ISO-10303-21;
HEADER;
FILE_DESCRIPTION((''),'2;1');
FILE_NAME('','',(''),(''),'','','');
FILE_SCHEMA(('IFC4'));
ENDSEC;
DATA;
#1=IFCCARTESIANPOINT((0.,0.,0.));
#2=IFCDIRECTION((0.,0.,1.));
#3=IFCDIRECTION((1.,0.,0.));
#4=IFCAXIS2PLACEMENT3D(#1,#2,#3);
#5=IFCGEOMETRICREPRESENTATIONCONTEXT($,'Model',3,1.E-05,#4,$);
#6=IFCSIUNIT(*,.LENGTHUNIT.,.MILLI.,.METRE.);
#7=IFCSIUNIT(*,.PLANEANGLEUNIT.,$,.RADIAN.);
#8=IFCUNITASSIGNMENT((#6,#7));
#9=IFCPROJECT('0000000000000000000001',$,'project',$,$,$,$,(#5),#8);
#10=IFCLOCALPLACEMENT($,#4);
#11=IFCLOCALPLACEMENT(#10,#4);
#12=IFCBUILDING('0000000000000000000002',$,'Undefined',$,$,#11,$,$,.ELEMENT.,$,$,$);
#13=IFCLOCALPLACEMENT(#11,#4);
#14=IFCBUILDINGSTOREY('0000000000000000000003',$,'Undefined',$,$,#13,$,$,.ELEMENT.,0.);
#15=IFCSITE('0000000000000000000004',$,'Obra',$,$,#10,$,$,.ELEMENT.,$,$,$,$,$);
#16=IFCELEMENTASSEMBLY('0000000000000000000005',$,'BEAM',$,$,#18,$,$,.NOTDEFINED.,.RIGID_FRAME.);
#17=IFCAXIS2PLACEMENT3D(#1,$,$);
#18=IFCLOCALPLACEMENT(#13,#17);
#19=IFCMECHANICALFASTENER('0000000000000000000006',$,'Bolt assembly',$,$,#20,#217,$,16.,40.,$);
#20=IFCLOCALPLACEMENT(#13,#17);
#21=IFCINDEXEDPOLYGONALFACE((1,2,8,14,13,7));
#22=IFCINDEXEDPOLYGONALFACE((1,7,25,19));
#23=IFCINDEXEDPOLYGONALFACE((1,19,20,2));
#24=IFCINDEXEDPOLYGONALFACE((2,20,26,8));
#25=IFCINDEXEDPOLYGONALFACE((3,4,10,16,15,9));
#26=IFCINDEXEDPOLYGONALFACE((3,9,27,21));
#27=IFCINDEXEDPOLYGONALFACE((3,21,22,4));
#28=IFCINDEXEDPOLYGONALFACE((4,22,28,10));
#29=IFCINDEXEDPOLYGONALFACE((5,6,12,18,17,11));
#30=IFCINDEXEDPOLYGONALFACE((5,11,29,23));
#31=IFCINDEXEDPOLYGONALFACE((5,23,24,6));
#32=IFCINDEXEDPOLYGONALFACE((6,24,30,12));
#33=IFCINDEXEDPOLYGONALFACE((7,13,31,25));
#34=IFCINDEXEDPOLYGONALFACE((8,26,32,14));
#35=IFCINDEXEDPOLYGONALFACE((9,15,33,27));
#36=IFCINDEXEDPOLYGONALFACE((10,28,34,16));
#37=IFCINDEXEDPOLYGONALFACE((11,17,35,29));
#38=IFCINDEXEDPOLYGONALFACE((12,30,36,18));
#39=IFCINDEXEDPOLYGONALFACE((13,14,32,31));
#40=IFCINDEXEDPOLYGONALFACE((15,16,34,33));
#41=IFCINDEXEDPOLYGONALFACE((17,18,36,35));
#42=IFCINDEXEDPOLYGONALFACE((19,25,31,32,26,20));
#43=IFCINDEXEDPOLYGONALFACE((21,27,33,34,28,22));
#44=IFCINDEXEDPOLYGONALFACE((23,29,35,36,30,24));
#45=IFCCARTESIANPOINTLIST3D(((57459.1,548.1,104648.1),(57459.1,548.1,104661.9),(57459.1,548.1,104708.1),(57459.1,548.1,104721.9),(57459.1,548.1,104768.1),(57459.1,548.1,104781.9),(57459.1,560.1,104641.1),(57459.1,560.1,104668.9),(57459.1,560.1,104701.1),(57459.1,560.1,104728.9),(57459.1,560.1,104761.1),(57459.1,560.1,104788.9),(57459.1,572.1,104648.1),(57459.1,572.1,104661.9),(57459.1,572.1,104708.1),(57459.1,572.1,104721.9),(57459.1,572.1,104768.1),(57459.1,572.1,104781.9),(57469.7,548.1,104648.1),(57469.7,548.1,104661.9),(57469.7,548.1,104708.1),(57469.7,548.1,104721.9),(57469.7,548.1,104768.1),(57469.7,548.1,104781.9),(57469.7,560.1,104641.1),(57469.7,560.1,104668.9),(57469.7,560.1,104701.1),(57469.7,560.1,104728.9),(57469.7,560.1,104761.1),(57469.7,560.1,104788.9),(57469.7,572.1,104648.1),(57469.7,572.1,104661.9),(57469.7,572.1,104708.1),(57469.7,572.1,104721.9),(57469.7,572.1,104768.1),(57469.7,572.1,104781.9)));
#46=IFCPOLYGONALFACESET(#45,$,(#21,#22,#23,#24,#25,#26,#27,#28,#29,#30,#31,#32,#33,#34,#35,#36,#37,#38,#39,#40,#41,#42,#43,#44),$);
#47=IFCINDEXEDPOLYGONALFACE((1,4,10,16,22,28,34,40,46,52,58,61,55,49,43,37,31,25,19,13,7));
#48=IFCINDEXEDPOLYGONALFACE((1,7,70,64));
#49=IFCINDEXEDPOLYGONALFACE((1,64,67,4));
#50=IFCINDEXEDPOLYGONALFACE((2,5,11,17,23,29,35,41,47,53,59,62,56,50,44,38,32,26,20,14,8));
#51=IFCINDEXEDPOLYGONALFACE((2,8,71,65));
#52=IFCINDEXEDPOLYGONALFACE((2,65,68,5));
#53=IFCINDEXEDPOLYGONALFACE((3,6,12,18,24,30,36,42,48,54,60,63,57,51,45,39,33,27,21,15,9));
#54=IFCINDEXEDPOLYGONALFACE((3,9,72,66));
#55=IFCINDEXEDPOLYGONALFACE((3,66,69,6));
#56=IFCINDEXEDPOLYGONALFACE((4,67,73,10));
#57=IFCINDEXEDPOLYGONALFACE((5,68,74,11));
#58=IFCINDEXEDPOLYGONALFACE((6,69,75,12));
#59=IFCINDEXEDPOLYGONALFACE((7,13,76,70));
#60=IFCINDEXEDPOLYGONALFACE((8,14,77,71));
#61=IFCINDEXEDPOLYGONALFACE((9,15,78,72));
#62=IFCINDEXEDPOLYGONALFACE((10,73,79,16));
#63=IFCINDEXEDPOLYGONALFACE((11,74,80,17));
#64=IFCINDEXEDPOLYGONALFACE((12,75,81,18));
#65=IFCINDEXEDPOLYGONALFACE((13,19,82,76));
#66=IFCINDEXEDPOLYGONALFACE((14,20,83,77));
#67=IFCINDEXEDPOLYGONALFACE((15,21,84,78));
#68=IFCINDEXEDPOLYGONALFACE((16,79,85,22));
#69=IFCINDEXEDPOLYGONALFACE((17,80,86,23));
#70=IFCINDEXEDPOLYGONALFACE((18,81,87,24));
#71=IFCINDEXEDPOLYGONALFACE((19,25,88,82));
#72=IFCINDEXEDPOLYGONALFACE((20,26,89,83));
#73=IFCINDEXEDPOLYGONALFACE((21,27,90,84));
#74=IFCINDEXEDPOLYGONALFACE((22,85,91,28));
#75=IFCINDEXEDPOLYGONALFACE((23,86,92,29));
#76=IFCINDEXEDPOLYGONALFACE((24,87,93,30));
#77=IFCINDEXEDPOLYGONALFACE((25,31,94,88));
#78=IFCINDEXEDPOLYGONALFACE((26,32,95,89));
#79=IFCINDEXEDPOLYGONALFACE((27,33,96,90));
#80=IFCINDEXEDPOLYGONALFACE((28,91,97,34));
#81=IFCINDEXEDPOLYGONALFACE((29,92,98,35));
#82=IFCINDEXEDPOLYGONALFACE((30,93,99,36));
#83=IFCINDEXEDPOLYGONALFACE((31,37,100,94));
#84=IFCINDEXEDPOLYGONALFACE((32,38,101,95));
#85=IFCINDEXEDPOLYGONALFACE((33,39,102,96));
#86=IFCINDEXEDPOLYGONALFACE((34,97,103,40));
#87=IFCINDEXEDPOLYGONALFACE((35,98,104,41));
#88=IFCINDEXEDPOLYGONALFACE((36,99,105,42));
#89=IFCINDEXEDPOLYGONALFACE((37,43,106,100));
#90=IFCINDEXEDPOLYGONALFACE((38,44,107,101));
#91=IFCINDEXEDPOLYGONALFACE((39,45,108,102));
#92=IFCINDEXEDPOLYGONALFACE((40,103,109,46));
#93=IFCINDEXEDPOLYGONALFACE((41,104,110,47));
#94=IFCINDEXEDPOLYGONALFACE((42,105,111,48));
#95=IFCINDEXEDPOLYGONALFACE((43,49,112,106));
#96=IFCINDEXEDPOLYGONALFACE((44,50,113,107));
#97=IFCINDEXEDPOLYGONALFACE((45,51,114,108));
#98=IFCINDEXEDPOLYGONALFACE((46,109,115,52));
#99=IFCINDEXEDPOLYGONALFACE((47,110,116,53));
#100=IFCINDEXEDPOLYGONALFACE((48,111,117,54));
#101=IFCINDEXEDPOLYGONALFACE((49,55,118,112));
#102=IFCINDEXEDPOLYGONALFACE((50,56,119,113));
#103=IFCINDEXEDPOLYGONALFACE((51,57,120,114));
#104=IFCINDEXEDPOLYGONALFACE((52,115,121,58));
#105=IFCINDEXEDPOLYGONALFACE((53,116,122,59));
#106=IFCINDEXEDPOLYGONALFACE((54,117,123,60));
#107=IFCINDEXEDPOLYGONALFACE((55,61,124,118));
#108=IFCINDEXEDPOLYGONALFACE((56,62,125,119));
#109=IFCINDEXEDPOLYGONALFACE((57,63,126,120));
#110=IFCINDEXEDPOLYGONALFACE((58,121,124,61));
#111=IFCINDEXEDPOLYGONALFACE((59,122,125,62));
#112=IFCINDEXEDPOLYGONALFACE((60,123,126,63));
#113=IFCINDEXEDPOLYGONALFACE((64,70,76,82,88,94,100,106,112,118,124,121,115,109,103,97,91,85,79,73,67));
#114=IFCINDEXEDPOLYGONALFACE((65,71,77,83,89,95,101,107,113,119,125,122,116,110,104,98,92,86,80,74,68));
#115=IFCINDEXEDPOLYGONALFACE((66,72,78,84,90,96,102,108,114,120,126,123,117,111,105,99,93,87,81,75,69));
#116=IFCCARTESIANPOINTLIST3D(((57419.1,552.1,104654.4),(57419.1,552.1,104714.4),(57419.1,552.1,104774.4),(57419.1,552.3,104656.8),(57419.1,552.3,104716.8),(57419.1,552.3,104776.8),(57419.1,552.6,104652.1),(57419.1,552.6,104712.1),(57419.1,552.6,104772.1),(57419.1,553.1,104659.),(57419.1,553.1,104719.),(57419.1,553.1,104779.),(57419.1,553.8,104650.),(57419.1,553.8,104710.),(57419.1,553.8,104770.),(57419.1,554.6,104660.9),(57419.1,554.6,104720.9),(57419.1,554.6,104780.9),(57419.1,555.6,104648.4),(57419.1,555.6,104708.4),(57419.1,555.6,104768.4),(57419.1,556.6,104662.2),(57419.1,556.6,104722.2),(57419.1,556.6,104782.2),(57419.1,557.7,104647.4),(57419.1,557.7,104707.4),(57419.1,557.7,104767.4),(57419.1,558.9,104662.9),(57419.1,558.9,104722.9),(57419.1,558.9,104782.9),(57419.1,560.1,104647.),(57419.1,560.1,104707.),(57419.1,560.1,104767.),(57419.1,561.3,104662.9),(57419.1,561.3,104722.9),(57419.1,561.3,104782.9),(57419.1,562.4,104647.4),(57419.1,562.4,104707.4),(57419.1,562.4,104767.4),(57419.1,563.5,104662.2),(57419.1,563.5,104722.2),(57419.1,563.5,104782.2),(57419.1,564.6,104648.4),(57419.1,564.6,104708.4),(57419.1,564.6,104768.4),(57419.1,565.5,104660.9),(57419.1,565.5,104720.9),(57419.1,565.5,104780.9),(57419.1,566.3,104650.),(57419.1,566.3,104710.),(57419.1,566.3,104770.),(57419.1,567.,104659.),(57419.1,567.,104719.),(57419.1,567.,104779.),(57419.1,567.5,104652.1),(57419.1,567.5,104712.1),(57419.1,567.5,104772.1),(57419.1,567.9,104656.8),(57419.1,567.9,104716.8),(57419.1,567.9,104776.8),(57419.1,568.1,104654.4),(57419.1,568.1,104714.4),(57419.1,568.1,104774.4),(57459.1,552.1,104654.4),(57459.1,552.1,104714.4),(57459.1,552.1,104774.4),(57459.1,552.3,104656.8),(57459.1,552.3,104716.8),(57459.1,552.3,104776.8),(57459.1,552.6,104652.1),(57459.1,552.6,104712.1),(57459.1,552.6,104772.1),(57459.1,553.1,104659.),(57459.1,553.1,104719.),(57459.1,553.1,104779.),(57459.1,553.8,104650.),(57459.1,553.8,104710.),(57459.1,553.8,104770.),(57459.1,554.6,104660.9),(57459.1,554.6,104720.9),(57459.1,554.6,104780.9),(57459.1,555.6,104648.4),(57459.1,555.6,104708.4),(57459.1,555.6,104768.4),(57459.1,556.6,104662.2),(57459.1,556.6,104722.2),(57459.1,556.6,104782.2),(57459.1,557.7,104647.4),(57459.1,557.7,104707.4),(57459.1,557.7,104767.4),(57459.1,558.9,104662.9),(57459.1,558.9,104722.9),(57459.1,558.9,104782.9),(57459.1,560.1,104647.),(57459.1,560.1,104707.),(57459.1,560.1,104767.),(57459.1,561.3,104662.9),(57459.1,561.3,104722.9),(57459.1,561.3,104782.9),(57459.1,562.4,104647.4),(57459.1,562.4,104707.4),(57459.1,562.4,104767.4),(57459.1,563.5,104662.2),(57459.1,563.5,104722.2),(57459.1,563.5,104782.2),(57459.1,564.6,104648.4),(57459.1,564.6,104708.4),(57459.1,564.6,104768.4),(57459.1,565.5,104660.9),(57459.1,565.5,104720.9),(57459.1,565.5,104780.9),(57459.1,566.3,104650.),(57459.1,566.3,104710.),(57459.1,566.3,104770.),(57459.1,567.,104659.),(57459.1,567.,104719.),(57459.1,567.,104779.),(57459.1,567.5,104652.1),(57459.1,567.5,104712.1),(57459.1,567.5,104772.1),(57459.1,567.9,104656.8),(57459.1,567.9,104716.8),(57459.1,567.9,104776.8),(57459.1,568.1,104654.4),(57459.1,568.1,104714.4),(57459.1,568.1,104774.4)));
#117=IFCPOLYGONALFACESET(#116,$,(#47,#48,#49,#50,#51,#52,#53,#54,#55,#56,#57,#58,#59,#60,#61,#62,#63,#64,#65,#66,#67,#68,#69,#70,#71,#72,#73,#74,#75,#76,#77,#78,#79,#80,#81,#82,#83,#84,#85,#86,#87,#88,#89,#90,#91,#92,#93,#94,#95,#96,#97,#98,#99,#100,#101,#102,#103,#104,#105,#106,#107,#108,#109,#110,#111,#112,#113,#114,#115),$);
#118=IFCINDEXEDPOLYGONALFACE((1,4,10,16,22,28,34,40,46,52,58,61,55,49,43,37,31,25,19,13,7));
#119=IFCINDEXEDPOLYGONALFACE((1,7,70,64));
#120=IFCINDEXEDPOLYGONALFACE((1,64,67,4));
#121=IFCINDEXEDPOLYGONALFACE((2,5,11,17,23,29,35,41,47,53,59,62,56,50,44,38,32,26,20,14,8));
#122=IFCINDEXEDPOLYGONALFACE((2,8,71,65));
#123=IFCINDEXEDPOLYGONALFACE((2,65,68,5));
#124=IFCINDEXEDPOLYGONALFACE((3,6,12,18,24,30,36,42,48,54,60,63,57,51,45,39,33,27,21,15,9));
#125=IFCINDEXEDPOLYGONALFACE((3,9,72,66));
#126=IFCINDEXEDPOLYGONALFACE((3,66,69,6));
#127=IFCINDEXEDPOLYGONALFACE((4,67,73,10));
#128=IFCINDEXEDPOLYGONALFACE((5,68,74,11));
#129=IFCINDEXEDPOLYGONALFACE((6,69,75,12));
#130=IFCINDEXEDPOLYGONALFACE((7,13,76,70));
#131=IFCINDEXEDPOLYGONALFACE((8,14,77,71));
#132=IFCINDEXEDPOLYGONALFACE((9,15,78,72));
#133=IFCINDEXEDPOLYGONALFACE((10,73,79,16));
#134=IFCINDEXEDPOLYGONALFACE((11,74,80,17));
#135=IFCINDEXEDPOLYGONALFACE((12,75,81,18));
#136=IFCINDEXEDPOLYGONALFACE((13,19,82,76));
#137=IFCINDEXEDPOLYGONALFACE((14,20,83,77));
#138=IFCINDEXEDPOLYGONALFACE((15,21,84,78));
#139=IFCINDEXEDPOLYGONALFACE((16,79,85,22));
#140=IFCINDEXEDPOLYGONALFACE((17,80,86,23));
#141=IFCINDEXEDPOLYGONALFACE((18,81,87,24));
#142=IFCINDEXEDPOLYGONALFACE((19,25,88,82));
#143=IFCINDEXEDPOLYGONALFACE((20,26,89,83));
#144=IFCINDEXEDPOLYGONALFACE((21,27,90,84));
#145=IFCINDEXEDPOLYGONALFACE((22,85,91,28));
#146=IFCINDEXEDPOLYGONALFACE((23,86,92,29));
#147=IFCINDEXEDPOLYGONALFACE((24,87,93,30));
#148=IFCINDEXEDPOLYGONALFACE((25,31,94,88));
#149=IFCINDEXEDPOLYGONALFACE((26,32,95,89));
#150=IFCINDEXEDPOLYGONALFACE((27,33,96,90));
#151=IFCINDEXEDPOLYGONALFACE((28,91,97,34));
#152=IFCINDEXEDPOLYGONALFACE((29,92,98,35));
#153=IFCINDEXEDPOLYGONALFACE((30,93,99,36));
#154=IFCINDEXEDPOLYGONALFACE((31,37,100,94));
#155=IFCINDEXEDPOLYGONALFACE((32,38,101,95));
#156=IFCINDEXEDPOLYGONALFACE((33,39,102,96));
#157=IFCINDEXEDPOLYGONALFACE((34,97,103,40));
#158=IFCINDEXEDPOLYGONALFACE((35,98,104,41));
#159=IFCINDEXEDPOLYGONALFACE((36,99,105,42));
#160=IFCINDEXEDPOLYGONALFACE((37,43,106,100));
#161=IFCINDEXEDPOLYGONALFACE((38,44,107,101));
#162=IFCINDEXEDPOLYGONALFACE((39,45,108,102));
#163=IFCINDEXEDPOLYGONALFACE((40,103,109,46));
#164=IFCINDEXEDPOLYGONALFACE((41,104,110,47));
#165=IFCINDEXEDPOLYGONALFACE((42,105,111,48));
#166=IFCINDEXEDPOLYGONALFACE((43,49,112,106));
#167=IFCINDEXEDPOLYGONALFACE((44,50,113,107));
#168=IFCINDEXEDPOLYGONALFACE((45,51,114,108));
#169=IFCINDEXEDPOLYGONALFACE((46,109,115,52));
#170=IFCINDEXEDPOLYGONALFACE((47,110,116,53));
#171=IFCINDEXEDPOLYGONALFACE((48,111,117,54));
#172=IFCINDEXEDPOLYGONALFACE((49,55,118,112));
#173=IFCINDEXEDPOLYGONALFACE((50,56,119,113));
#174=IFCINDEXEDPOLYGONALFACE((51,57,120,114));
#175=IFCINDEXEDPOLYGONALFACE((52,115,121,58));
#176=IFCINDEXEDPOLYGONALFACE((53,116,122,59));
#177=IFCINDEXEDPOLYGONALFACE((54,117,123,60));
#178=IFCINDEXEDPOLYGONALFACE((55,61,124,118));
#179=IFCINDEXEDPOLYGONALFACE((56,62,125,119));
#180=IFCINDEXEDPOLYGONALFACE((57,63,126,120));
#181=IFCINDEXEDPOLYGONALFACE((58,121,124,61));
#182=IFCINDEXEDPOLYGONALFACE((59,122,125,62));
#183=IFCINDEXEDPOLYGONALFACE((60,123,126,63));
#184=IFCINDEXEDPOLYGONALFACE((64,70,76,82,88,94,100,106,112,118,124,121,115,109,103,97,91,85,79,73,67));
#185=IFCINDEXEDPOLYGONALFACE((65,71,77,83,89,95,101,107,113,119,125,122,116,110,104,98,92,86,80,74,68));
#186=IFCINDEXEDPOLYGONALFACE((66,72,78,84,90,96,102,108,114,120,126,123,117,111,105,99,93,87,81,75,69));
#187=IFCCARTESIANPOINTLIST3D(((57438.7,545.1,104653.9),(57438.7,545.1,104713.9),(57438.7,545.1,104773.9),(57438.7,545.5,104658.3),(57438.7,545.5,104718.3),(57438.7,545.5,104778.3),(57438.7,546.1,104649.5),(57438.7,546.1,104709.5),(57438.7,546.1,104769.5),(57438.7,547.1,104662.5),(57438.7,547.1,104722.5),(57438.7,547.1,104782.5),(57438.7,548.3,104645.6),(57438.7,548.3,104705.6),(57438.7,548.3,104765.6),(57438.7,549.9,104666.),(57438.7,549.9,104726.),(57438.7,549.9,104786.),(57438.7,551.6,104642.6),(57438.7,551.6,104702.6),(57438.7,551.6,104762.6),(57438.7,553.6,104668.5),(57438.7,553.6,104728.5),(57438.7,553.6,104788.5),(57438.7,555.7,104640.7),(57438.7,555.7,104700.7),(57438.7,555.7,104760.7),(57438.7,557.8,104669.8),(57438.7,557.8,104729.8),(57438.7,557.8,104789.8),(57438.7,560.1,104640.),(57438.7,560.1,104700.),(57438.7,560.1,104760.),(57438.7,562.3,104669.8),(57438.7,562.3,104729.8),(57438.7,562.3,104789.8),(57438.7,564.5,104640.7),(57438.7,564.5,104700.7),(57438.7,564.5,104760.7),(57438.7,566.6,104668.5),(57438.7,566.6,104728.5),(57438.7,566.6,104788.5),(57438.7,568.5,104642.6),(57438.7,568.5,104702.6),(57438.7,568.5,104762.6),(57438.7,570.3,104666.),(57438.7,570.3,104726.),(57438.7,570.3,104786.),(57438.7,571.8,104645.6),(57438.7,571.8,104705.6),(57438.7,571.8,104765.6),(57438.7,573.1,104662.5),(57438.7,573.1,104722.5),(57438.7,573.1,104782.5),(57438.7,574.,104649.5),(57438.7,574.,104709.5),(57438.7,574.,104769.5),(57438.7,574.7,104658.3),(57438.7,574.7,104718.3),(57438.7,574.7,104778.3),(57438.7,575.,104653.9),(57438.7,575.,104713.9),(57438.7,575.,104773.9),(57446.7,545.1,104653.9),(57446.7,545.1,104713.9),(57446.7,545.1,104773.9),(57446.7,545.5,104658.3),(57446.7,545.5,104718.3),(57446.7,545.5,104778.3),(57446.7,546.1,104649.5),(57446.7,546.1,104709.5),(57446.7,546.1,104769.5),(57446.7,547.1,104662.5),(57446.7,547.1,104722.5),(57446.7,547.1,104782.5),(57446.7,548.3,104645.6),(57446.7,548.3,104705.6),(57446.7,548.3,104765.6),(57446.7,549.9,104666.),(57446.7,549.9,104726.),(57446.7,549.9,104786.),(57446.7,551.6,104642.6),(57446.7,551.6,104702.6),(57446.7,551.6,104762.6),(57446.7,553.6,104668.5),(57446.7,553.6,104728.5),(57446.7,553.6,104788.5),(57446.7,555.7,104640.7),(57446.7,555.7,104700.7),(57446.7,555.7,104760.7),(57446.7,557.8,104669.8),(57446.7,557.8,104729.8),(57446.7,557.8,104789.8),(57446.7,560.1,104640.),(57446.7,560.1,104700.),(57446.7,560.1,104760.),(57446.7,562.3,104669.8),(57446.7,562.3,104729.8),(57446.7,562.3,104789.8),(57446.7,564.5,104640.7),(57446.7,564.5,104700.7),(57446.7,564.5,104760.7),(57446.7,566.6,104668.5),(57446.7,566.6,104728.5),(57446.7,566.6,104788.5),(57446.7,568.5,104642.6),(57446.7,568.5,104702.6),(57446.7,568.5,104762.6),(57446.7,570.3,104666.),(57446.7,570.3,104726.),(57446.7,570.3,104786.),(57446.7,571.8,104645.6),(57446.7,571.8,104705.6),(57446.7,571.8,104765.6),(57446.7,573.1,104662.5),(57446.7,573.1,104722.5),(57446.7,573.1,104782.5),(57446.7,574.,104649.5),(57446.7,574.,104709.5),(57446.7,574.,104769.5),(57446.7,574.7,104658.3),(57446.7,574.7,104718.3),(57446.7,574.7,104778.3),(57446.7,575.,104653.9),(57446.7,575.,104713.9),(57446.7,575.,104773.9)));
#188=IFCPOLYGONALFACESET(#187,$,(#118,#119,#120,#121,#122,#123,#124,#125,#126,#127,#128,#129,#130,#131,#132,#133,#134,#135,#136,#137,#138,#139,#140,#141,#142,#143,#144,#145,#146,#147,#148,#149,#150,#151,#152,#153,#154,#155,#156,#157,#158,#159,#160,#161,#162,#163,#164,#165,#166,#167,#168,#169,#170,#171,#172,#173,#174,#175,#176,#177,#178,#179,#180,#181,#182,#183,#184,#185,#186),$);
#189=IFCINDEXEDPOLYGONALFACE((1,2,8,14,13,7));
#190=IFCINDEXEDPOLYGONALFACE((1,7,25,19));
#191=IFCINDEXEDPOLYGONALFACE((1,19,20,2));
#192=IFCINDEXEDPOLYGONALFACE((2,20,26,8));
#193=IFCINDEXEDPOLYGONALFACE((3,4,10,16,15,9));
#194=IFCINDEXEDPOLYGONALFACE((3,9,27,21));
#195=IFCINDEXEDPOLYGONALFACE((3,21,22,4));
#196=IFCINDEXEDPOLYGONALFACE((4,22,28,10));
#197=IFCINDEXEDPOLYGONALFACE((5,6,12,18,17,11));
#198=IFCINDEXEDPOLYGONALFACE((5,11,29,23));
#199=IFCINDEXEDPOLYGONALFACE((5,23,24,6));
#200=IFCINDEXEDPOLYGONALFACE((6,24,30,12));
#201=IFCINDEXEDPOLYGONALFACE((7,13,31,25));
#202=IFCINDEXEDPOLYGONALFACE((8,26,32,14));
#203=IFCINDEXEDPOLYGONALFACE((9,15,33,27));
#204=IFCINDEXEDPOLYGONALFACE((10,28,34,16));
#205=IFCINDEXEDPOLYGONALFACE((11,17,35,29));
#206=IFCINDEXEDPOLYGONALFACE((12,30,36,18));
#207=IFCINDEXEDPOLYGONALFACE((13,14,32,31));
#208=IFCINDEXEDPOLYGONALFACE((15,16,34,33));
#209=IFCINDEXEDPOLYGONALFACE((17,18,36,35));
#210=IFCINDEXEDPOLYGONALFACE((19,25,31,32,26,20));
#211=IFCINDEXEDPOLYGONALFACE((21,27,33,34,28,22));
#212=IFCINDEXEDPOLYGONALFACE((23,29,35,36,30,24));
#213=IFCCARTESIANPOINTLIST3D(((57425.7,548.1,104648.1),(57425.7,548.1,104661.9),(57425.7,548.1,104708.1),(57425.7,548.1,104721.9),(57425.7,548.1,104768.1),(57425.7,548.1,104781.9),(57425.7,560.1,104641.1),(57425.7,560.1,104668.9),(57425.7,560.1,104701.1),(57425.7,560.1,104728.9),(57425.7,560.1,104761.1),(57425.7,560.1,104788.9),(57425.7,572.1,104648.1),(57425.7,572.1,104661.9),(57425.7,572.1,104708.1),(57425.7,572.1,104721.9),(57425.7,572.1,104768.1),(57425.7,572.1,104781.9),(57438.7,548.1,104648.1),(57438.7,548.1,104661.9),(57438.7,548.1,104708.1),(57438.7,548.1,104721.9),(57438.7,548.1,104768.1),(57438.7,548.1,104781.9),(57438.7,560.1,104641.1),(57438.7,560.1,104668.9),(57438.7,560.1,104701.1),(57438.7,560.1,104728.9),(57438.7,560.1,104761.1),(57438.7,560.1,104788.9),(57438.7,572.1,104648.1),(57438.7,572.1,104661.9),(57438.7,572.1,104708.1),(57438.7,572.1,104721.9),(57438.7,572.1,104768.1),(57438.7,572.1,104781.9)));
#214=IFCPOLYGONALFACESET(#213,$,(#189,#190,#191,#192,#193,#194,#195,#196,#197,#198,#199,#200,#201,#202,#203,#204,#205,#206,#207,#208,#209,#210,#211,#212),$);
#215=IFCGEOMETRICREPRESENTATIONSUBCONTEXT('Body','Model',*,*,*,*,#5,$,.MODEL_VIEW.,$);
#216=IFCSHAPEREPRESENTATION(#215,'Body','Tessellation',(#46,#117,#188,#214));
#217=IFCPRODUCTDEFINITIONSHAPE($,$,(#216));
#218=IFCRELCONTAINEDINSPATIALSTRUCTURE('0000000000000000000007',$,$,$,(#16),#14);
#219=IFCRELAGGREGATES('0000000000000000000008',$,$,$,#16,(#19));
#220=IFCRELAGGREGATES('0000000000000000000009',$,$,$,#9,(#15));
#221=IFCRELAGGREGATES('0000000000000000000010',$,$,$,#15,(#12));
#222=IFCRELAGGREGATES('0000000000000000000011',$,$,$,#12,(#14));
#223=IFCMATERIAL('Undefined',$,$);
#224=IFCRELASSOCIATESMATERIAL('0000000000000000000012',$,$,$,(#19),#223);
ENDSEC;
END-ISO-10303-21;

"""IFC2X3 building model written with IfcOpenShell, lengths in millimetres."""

from ifc_helpers import new_model, si_unit, frame, origin_with_axes, origin_2d_with_axis, place, context, subcontext, project, spatial, polyline, circle, outline, extrude, source, transform, mapped, material, element, aggregate, save


model = new_model("IFC2X3")

# Units and contexts
model_context = context("Model", 3, precision=1e-05, world=origin_with_axes())
body_context = subcontext(model_context, "Body", "Model", "MODEL_VIEW")
ifc_project = project(units=[si_unit("LENGTHUNIT", "METRE", prefix="MILLI"), si_unit("PLANEANGLEUNIT", "RADIAN")], contexts=[model_context])

# Site, building, storey
site_placement = place(None, origin_with_axes())
site = spatial("IfcSite", under=ifc_project, at=site_placement, Name="Obra", CompositionType="ELEMENT")
building_placement = place(site_placement, origin_with_axes())
building = spatial("IfcBuilding", under=site, at=building_placement, Name="Undefined", CompositionType="ELEMENT")
storey_placement = place(building_placement, origin_with_axes())
storey = spatial("IfcBuildingStorey", under=building, at=storey_placement, Name="Undefined", CompositionType="ELEMENT", Elevation=0.0)

# Element assembly, mechanical fastener
assembly_1_placement = place(storey_placement, origin_with_axes())
assembly_1 = element("IfcElementAssembly", 1, at=assembly_1_placement, inside=storey, Name="BEAM", AssemblyPlace="NOTDEFINED", PredefinedType="RIGID_FRAME")
ifc_material_1 = material(Name="Undefined")
shared_shape_1 = source(origin_with_axes(), body_context, "Body", "SweptSolid", [
    extrude(outline(polyline([(13.9, 0.0), (6.9, 12.0), (-6.9, 12.0), (-13.9, 0.0), (-6.9, -12.0), (6.9, -12.0), (13.9, 0.0)])), frame((0.0, -19.7, 0.0), z_axis=(0.0, 1.0, 0.0), x_axis=(1.0, 0.0, 0.0)), (0.0, 0.0, 1.0), 10.6),
    extrude(circle(Radius=8.0, at=origin_2d_with_axis()), frame((0.0, -9.1, 0.0), z_axis=(0.0, 1.0, 0.0), x_axis=(1.0, 0.0, 0.0)), (0.0, 0.0, 1.0), 40.0),
    extrude(circle(Radius=15.0, at=origin_2d_with_axis()), frame((0.0, 3.3, 0.0), z_axis=(0.0, 1.0, 0.0), x_axis=(1.0, 0.0, 0.0)), (0.0, 0.0, 1.0), 8.0),
    extrude(outline(polyline([(13.9, 0.0), (6.9, 12.0), (-6.9, 12.0), (-13.9, 0.0), (-6.9, -12.0), (6.9, -12.0), (13.9, 0.0)])), frame((0.0, 11.3, 0.0), z_axis=(0.0, 1.0, 0.0), x_axis=(1.0, 0.0, 0.0)), (0.0, 0.0, 1.0), 13.0),
])
mechanical_fastener_1_placement = place(assembly_1_placement, frame((57450.0, 510.1, 104835.0), z_axis=(-0.000002, 1.0, 0.0), x_axis=(0.0, 0.0, -1.0)))
mechanical_fastener_1 = element("IfcMechanicalFastener", 2, at=mechanical_fastener_1_placement, material=ifc_material_1, Name="Bolt assembly", NominalDiameter=16.0, NominalLength=40.0, context=body_context, shape_type="MappedRepresentation", body=[
    mapped(shared_shape_1, transform((60.0, 0.0, 50.0))),
    mapped(shared_shape_1, transform((120.0, 0.0, 50.0))),
    mapped(shared_shape_1, transform((180.0, 0.0, 50.0))),
])

aggregate(assembly_1, [mechanical_fastener_1])

save(model, "model.ifc")
